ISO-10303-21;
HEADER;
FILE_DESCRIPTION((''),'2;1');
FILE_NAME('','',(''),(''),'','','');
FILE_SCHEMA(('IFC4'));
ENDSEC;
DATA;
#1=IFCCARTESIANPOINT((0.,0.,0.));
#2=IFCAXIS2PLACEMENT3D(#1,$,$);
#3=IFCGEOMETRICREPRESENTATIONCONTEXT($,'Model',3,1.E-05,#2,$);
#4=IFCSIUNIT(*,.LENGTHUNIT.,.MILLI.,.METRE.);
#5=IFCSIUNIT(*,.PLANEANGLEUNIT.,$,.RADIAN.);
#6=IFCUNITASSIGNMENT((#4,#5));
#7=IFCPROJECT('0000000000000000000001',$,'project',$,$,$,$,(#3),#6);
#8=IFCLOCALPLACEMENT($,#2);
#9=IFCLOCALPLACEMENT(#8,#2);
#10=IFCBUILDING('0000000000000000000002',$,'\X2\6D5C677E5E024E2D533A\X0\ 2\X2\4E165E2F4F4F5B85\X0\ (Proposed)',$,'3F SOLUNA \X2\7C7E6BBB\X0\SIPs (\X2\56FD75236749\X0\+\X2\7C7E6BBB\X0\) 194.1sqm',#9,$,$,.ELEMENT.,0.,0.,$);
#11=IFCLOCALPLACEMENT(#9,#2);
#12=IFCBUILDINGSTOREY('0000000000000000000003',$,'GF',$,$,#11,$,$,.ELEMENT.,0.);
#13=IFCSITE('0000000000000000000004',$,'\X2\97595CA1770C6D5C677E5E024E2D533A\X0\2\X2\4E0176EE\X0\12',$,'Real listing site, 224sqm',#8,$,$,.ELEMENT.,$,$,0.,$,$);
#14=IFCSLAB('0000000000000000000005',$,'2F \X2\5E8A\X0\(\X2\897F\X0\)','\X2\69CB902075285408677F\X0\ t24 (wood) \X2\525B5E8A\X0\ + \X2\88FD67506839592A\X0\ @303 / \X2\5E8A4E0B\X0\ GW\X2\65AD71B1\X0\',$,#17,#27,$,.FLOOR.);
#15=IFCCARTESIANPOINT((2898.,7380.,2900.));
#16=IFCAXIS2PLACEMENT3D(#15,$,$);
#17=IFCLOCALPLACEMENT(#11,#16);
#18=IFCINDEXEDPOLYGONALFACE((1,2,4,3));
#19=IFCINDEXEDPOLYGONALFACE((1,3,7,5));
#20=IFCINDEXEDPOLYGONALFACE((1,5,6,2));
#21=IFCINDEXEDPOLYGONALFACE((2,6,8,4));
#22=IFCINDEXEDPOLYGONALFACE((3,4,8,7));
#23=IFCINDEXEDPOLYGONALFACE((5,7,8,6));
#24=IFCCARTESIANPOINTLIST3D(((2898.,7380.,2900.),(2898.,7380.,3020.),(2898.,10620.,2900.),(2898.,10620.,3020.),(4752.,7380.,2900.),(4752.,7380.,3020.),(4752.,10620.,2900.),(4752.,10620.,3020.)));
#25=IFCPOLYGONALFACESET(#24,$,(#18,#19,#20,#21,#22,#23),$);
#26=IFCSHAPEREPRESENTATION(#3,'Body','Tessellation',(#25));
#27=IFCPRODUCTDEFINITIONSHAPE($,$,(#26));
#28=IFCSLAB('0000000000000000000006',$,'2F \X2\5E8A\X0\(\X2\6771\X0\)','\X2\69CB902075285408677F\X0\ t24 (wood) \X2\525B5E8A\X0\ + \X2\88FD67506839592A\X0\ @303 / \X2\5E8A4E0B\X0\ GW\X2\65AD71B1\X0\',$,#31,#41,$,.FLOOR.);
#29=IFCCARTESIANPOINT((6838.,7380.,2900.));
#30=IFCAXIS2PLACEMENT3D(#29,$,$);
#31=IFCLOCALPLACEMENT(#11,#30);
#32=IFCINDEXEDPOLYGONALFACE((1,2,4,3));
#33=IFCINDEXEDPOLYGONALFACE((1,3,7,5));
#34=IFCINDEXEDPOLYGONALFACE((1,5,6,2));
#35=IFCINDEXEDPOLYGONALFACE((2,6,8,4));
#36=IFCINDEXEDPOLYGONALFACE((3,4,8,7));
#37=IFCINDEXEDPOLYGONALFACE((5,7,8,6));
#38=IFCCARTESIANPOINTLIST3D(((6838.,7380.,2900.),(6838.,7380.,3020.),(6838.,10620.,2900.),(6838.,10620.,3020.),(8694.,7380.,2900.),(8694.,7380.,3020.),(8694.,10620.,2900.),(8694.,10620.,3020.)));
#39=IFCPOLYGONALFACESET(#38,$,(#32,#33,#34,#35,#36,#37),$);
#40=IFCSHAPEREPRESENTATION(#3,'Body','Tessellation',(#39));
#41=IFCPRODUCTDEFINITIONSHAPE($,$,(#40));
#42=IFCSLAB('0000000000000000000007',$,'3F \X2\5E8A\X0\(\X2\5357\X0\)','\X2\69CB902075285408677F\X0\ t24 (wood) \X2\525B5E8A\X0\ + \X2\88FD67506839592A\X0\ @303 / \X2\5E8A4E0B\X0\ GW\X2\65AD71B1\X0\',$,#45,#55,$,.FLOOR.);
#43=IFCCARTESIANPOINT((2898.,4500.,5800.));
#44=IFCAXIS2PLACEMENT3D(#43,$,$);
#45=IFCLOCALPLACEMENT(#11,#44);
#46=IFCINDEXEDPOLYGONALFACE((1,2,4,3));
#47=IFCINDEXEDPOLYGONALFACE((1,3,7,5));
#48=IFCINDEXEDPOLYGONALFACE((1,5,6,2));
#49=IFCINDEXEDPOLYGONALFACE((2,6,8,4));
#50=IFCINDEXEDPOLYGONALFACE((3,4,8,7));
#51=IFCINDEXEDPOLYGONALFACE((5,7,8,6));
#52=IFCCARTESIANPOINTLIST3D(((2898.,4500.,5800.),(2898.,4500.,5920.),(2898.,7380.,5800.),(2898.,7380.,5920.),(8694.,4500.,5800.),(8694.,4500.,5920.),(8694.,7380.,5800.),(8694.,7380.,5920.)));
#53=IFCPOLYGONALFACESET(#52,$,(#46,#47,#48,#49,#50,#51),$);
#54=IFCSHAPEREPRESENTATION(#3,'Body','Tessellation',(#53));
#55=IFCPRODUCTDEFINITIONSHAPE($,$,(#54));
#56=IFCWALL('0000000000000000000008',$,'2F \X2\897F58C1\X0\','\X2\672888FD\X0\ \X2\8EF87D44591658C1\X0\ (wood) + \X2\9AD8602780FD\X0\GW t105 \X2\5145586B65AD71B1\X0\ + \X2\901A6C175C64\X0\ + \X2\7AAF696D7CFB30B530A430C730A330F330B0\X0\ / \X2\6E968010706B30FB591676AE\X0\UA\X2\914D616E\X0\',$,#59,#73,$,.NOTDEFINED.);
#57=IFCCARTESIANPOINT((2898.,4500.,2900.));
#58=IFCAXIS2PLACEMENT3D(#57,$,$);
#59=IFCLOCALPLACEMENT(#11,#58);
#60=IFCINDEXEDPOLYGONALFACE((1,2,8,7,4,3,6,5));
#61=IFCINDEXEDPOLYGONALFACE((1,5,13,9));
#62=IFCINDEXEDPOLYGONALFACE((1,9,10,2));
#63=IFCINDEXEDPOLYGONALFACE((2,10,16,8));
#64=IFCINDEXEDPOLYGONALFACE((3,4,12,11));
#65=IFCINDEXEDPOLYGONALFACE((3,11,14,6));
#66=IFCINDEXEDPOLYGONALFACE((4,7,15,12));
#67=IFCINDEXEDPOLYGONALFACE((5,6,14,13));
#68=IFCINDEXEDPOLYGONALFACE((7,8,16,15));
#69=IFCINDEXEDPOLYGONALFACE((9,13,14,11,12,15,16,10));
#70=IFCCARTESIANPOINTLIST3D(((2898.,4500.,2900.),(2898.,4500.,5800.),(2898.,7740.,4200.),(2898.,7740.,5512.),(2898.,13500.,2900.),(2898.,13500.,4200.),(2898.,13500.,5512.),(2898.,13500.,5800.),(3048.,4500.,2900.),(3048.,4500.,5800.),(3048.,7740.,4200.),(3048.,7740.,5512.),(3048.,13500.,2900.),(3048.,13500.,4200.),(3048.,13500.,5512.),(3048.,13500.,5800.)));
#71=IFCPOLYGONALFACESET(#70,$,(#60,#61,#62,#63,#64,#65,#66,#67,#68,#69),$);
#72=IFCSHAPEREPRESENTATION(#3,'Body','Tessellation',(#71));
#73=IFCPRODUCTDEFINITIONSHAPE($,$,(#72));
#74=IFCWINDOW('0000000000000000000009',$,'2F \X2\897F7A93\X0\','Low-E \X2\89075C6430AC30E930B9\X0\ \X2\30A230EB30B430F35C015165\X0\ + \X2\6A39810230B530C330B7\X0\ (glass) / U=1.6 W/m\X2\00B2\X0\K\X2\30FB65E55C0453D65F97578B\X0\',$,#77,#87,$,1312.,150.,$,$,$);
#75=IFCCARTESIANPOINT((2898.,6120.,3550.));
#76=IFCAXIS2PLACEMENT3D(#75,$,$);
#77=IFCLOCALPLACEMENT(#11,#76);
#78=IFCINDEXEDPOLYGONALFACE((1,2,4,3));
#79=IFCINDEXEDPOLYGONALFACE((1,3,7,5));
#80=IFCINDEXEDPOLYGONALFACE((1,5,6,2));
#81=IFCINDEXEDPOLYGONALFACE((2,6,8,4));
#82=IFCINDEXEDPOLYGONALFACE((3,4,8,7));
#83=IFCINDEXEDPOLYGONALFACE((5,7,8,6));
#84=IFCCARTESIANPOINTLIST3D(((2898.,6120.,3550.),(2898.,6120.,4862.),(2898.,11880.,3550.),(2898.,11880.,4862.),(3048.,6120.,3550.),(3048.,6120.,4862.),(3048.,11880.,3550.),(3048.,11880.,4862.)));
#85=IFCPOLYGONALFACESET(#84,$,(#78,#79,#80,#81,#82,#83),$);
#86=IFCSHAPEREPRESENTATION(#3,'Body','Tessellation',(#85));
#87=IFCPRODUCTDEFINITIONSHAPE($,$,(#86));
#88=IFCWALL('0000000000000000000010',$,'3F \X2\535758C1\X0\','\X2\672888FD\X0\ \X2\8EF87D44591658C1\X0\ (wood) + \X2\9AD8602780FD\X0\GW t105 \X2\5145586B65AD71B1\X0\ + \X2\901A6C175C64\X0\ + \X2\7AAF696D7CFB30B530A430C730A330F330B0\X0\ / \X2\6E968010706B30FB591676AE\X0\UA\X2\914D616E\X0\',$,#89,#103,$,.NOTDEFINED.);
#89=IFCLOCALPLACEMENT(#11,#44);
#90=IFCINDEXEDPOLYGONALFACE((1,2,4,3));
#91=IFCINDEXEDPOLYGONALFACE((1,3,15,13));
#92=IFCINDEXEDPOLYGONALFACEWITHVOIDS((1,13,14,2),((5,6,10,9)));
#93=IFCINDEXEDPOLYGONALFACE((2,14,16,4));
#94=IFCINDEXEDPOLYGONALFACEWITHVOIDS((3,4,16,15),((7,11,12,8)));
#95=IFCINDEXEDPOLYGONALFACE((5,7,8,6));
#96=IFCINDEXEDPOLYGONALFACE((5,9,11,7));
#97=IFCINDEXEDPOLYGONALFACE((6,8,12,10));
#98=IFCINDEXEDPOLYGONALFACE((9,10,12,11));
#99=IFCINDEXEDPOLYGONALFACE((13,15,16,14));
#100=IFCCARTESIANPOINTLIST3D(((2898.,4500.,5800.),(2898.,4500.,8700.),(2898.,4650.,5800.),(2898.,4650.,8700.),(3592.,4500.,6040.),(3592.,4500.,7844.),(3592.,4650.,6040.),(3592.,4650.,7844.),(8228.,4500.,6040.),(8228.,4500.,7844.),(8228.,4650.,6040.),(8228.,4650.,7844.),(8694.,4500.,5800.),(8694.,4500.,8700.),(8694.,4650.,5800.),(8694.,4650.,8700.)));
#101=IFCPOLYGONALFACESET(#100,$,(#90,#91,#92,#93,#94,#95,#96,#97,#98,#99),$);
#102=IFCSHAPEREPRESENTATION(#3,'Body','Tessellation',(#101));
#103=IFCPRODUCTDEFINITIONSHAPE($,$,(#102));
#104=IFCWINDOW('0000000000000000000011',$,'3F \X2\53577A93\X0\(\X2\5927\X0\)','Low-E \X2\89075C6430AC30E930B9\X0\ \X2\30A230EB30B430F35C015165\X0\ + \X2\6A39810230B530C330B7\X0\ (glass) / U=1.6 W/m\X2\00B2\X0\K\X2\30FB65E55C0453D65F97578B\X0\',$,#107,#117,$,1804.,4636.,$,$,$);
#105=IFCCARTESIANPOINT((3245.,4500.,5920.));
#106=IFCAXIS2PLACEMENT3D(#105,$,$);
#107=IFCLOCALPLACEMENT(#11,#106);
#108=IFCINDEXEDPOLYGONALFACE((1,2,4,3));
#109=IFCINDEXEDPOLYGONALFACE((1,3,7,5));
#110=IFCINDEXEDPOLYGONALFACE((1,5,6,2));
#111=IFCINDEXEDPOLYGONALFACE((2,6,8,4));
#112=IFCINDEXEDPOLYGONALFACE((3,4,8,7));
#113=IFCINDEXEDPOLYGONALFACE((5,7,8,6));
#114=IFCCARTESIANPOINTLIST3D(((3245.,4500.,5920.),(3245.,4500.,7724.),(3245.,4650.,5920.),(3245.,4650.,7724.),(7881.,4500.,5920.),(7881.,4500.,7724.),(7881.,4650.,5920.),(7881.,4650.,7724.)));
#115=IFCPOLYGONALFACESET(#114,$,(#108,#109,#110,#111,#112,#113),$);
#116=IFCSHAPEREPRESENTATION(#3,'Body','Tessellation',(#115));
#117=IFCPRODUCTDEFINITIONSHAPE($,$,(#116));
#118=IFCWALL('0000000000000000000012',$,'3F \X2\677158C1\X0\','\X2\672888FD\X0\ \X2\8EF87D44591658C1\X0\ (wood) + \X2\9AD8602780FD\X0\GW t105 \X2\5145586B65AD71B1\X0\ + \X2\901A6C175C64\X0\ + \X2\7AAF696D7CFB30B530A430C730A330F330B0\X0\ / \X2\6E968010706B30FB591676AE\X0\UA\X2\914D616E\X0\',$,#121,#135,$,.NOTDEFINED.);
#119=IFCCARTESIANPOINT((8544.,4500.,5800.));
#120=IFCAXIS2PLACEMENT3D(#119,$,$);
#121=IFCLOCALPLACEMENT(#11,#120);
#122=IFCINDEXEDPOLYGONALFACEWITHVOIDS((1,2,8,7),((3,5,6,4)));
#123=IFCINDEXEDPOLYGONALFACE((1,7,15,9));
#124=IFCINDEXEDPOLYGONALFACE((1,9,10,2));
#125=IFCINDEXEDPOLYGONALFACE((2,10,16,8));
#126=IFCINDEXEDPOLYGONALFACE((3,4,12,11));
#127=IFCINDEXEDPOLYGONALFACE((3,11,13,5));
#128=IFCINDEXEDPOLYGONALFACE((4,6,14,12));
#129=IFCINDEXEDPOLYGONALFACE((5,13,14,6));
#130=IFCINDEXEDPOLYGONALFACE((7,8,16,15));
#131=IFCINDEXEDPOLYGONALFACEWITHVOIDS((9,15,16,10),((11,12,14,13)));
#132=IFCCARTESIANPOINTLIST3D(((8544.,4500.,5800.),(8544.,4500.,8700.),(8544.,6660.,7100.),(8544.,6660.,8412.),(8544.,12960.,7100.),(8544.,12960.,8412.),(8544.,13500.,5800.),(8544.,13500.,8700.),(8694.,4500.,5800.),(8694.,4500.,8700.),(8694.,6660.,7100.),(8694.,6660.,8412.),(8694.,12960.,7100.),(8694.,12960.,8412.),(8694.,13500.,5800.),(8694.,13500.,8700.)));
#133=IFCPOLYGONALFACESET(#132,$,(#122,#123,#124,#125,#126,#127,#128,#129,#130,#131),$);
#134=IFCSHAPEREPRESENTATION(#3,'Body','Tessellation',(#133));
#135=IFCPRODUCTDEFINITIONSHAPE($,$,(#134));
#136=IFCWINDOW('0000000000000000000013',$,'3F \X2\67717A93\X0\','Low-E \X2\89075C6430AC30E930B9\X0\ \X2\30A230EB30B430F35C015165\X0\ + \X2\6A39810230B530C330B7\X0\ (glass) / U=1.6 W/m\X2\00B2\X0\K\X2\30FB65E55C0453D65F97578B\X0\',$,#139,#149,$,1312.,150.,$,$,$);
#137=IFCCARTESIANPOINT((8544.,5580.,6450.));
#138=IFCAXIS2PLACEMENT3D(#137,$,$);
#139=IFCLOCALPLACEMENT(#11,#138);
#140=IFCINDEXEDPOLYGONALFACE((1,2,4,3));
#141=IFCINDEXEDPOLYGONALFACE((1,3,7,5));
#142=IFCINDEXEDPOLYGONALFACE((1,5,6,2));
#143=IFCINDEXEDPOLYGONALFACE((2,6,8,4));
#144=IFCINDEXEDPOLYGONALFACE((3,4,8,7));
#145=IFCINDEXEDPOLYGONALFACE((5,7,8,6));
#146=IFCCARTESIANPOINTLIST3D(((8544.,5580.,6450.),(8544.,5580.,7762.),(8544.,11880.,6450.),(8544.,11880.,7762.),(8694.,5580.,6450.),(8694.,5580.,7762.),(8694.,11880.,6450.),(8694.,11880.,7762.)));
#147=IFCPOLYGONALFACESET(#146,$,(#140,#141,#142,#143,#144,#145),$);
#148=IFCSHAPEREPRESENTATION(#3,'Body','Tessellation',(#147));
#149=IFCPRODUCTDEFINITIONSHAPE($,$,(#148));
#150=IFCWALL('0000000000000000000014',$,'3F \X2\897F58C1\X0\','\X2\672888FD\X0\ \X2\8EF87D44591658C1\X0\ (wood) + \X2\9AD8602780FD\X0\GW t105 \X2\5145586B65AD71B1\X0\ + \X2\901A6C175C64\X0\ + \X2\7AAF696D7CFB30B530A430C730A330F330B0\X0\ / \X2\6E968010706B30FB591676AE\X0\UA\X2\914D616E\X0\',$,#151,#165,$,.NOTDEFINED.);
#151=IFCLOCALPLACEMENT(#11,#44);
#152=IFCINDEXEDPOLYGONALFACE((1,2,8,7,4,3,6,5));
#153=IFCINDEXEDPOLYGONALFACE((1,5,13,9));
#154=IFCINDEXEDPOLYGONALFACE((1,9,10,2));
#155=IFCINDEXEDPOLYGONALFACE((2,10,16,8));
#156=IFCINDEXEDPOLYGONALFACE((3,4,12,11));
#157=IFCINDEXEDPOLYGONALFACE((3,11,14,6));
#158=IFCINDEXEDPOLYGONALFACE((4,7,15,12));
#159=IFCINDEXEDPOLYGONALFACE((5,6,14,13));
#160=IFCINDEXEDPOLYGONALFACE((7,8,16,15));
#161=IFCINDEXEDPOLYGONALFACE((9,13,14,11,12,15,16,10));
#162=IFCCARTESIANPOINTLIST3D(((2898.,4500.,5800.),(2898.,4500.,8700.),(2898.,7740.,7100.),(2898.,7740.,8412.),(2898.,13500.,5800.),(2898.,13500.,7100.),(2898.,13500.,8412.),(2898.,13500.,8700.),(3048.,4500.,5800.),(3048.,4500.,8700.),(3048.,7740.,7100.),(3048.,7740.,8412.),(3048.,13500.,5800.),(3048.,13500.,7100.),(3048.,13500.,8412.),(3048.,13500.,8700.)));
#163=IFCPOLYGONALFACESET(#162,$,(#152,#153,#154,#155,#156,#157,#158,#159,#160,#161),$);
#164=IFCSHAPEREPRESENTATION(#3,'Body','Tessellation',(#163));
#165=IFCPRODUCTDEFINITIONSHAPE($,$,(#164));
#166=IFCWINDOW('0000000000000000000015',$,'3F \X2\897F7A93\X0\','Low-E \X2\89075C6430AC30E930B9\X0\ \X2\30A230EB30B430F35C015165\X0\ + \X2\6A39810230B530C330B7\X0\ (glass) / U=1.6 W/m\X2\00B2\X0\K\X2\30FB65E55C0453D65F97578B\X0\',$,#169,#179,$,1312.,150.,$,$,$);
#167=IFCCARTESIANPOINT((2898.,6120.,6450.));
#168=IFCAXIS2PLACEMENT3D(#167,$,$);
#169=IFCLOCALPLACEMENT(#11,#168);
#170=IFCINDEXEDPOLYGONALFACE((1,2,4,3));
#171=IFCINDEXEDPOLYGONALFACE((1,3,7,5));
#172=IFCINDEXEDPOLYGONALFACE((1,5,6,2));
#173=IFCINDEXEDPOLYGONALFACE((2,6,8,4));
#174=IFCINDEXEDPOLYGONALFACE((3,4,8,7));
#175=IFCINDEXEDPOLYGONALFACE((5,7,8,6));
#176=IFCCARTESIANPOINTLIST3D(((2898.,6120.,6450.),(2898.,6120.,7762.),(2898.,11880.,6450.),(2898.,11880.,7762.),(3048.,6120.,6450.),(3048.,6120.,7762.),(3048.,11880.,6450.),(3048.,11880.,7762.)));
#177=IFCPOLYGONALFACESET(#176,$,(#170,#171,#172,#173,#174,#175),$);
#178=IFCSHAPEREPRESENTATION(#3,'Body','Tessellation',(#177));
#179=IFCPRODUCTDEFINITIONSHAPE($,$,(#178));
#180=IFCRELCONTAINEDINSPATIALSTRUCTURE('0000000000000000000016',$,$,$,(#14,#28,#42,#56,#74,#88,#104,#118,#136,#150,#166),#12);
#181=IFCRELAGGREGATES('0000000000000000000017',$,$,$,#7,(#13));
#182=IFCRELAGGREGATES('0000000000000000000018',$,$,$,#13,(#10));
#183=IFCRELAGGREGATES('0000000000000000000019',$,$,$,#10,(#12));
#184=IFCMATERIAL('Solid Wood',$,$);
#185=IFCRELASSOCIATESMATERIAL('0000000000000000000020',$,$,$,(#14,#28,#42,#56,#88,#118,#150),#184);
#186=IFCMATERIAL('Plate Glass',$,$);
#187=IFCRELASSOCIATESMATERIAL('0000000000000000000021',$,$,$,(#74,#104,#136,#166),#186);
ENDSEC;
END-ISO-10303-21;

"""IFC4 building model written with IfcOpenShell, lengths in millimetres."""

from ifc_helpers import new_model, si_unit, frame, frame_2d, origin, place, context, project, spatial, rectangle, extrude, material, element, fill, save


model = new_model("IFC4")

# Units and contexts
model_context = context("Model", 3, precision=1e-05, world=origin())
ifc_project = project(units=[si_unit("LENGTHUNIT", "METRE", prefix="MILLI"), si_unit("PLANEANGLEUNIT", "RADIAN")], contexts=[model_context])

# Site, building, storey
site_placement = place(None, origin())
site = spatial("IfcSite", under=ifc_project, at=site_placement, Name="静岡県浜松市中区2丁目12", ObjectType="Real listing site, 224sqm", CompositionType="ELEMENT", RefElevation=0.0)
building_placement = place(site_placement, origin())
building = spatial("IfcBuilding", under=site, at=building_placement, Name="浜松市中区 2世帯住宅 (Proposed)", ObjectType="3F SOLUNA 籾殻SIPs (国産杉+籾殻) 194.1sqm", CompositionType="ELEMENT", ElevationOfRefHeight=0.0, ElevationOfTerrain=0.0)
storey_placement = place(building_placement, origin())
storey = spatial("IfcBuildingStorey", under=building, at=storey_placement, Name="GF", CompositionType="ELEMENT", Elevation=0.0)

# Slabs
ifc_material_1 = material(Name="Solid Wood")
slab_1_placement = place(storey_placement, frame((2898.0, 7380.0, 2900.0)))
element("IfcSlab", 1, at=slab_1_placement, inside=storey, material=ifc_material_1, Name="2F 床(西)", Description="構造用合板 t24 (wood) 剛床 + 製材根太 @303 / 床下 GW断熱", PredefinedType="FLOOR", context=model_context, shape_type="SweptSolid", body=[
    extrude(rectangle(XDim=1854.0, YDim=3240.0, at=frame_2d((927.0, 1620.0))), frame((2898.0, 7380.0, 2900.0)), (0.0, 0.0, 1.0), 120.0),
])
slab_2_placement = place(storey_placement, frame((6838.0, 7380.0, 2900.0)))
element("IfcSlab", 2, at=slab_2_placement, inside=storey, material=ifc_material_1, Name="2F 床(東)", Description="構造用合板 t24 (wood) 剛床 + 製材根太 @303 / 床下 GW断熱", PredefinedType="FLOOR", context=model_context, shape_type="SweptSolid", body=[
    extrude(rectangle(XDim=1856.0, YDim=3240.0, at=frame_2d((928.0, 1620.0))), frame((6838.0, 7380.0, 2900.0)), (0.0, 0.0, 1.0), 120.0),
])
slab_3_placement = place(storey_placement, frame((2898.0, 4500.0, 5800.0)))
element("IfcSlab", 3, at=slab_3_placement, inside=storey, material=ifc_material_1, Name="3F 床(南)", Description="構造用合板 t24 (wood) 剛床 + 製材根太 @303 / 床下 GW断熱", PredefinedType="FLOOR", context=model_context, shape_type="SweptSolid", body=[
    extrude(rectangle(XDim=5796.0, YDim=2880.0, at=frame_2d((2898.0, 1440.0))), frame((2898.0, 4500.0, 5800.0)), (0.0, 0.0, 1.0), 120.0),
])

# Walls, openings, windows
wall_1_placement = place(storey_placement, frame((2898.0, 4500.0, 2900.0)))
wall_1 = element("IfcWall", 4, at=wall_1_placement, inside=storey, material=ifc_material_1, Name="2F 西壁", Description="木製 軸組外壁 (wood) + 高性能GW t105 充填断熱 + 通気層 + 窯業系サイディング / 準耐火・外皮UA配慮", PredefinedType="NOTDEFINED", context=model_context, shape_type="SweptSolid", body=[
    extrude(rectangle(XDim=150.0, YDim=9000.0, at=frame_2d((75.0, 4500.0))), frame((2898.0, 4500.0, 2900.0)), (0.0, 0.0, 1.0), 2900.0),
])
opening_1_placement = place(storey_placement, frame((2898.0, 6120.0, 3550.0)))
opening_1 = element("IfcOpeningElement", 5, at=opening_1_placement, cuts=wall_1, PredefinedType="NOTDEFINED", context=model_context, shape_type="SweptSolid", body=[
    extrude(rectangle(XDim=150.0, YDim=5760.0, at=frame_2d((75.0, 2880.0))), frame((2898.0, 6120.0, 3550.0)), (0.0, 0.0, 1.0), 1312.0),
])
ifc_material_2 = material(Name="Plate Glass")
window_1_placement = place(storey_placement, frame((2898.0, 6120.0, 3550.0)))
window_1 = element("IfcWindow", 6, at=window_1_placement, inside=storey, material=ifc_material_2, Name="2F 西窓", Description="Low-E 複層ガラス アルゴン封入 + 樹脂サッシ (glass) / U=1.6 W/m²K・日射取得型", OverallHeight=1312.0, OverallWidth=150.0, context=model_context, shape_type="SweptSolid", body=[
    extrude(rectangle(XDim=150.0, YDim=5760.0, at=frame_2d((75.0, 2880.0))), frame((2898.0, 6120.0, 3550.0)), (0.0, 0.0, 1.0), 1312.0),
])
fill(opening_1, window_1)
wall_2_placement = place(storey_placement, frame((2898.0, 4500.0, 5800.0)))
wall_2 = element("IfcWall", 7, at=wall_2_placement, inside=storey, material=ifc_material_1, Name="3F 南壁", Description="木製 軸組外壁 (wood) + 高性能GW t105 充填断熱 + 通気層 + 窯業系サイディング / 準耐火・外皮UA配慮", PredefinedType="NOTDEFINED", context=model_context, shape_type="SweptSolid", body=[
    extrude(rectangle(XDim=5796.0, YDim=150.0, at=frame_2d((2898.0, 75.0))), frame((2898.0, 4500.0, 5800.0)), (0.0, 0.0, 1.0), 2900.0),
])
opening_2_placement = place(storey_placement, frame((3245.0, 4500.0, 5920.0)))
opening_2 = element("IfcOpeningElement", 8, at=opening_2_placement, cuts=wall_2, PredefinedType="NOTDEFINED", context=model_context, shape_type="SweptSolid", body=[
    extrude(rectangle(XDim=4636.0, YDim=150.0, at=frame_2d((2318.0, 75.0))), frame((3245.0, 4500.0, 5920.0)), (0.0, 0.0, 1.0), 1804.0),
])
window_2_placement = place(storey_placement, frame((3245.0, 4500.0, 5920.0)))
window_2 = element("IfcWindow", 9, at=window_2_placement, inside=storey, material=ifc_material_2, Name="3F 南窓(大)", Description="Low-E 複層ガラス アルゴン封入 + 樹脂サッシ (glass) / U=1.6 W/m²K・日射取得型", OverallHeight=1804.0, OverallWidth=4636.0, context=model_context, shape_type="SweptSolid", body=[
    extrude(rectangle(XDim=4636.0, YDim=150.0, at=frame_2d((2318.0, 75.0))), frame((3245.0, 4500.0, 5920.0)), (0.0, 0.0, 1.0), 1804.0),
])
fill(opening_2, window_2)
wall_3_placement = place(storey_placement, frame((8544.0, 4500.0, 5800.0)))
wall_3 = element("IfcWall", 10, at=wall_3_placement, inside=storey, material=ifc_material_1, Name="3F 東壁", Description="木製 軸組外壁 (wood) + 高性能GW t105 充填断熱 + 通気層 + 窯業系サイディング / 準耐火・外皮UA配慮", PredefinedType="NOTDEFINED", context=model_context, shape_type="SweptSolid", body=[
    extrude(rectangle(XDim=150.0, YDim=9000.0, at=frame_2d((75.0, 4500.0))), frame((8544.0, 4500.0, 5800.0)), (0.0, 0.0, 1.0), 2900.0),
])
opening_3_placement = place(storey_placement, frame((8544.0, 5580.0, 6450.0)))
opening_3 = element("IfcOpeningElement", 11, at=opening_3_placement, cuts=wall_3, PredefinedType="NOTDEFINED", context=model_context, shape_type="SweptSolid", body=[
    extrude(rectangle(XDim=150.0, YDim=6300.0, at=frame_2d((75.0, 3150.0))), frame((8544.0, 5580.0, 6450.0)), (0.0, 0.0, 1.0), 1312.0),
])
window_3_placement = place(storey_placement, frame((8544.0, 5580.0, 6450.0)))
window_3 = element("IfcWindow", 12, at=window_3_placement, inside=storey, material=ifc_material_2, Name="3F 東窓", Description="Low-E 複層ガラス アルゴン封入 + 樹脂サッシ (glass) / U=1.6 W/m²K・日射取得型", OverallHeight=1312.0, OverallWidth=150.0, context=model_context, shape_type="SweptSolid", body=[
    extrude(rectangle(XDim=150.0, YDim=6300.0, at=frame_2d((75.0, 3150.0))), frame((8544.0, 5580.0, 6450.0)), (0.0, 0.0, 1.0), 1312.0),
])
fill(opening_3, window_3)
wall_4_placement = place(storey_placement, frame((2898.0, 4500.0, 5800.0)))
wall_4 = element("IfcWall", 13, at=wall_4_placement, inside=storey, material=ifc_material_1, Name="3F 西壁", Description="木製 軸組外壁 (wood) + 高性能GW t105 充填断熱 + 通気層 + 窯業系サイディング / 準耐火・外皮UA配慮", PredefinedType="NOTDEFINED", context=model_context, shape_type="SweptSolid", body=[
    extrude(rectangle(XDim=150.0, YDim=9000.0, at=frame_2d((75.0, 4500.0))), frame((2898.0, 4500.0, 5800.0)), (0.0, 0.0, 1.0), 2900.0),
])
opening_4_placement = place(storey_placement, frame((2898.0, 6120.0, 6450.0)))
opening_4 = element("IfcOpeningElement", 14, at=opening_4_placement, cuts=wall_4, PredefinedType="NOTDEFINED", context=model_context, shape_type="SweptSolid", body=[
    extrude(rectangle(XDim=150.0, YDim=5760.0, at=frame_2d((75.0, 2880.0))), frame((2898.0, 6120.0, 6450.0)), (0.0, 0.0, 1.0), 1312.0),
])
window_4_placement = place(storey_placement, frame((2898.0, 6120.0, 6450.0)))
window_4 = element("IfcWindow", 15, at=window_4_placement, inside=storey, material=ifc_material_2, Name="3F 西窓", Description="Low-E 複層ガラス アルゴン封入 + 樹脂サッシ (glass) / U=1.6 W/m²K・日射取得型", OverallHeight=1312.0, OverallWidth=150.0, context=model_context, shape_type="SweptSolid", body=[
    extrude(rectangle(XDim=150.0, YDim=5760.0, at=frame_2d((75.0, 2880.0))), frame((2898.0, 6120.0, 6450.0)), (0.0, 0.0, 1.0), 1312.0),
])
fill(opening_4, window_4)

save(model, "model.ifc")
